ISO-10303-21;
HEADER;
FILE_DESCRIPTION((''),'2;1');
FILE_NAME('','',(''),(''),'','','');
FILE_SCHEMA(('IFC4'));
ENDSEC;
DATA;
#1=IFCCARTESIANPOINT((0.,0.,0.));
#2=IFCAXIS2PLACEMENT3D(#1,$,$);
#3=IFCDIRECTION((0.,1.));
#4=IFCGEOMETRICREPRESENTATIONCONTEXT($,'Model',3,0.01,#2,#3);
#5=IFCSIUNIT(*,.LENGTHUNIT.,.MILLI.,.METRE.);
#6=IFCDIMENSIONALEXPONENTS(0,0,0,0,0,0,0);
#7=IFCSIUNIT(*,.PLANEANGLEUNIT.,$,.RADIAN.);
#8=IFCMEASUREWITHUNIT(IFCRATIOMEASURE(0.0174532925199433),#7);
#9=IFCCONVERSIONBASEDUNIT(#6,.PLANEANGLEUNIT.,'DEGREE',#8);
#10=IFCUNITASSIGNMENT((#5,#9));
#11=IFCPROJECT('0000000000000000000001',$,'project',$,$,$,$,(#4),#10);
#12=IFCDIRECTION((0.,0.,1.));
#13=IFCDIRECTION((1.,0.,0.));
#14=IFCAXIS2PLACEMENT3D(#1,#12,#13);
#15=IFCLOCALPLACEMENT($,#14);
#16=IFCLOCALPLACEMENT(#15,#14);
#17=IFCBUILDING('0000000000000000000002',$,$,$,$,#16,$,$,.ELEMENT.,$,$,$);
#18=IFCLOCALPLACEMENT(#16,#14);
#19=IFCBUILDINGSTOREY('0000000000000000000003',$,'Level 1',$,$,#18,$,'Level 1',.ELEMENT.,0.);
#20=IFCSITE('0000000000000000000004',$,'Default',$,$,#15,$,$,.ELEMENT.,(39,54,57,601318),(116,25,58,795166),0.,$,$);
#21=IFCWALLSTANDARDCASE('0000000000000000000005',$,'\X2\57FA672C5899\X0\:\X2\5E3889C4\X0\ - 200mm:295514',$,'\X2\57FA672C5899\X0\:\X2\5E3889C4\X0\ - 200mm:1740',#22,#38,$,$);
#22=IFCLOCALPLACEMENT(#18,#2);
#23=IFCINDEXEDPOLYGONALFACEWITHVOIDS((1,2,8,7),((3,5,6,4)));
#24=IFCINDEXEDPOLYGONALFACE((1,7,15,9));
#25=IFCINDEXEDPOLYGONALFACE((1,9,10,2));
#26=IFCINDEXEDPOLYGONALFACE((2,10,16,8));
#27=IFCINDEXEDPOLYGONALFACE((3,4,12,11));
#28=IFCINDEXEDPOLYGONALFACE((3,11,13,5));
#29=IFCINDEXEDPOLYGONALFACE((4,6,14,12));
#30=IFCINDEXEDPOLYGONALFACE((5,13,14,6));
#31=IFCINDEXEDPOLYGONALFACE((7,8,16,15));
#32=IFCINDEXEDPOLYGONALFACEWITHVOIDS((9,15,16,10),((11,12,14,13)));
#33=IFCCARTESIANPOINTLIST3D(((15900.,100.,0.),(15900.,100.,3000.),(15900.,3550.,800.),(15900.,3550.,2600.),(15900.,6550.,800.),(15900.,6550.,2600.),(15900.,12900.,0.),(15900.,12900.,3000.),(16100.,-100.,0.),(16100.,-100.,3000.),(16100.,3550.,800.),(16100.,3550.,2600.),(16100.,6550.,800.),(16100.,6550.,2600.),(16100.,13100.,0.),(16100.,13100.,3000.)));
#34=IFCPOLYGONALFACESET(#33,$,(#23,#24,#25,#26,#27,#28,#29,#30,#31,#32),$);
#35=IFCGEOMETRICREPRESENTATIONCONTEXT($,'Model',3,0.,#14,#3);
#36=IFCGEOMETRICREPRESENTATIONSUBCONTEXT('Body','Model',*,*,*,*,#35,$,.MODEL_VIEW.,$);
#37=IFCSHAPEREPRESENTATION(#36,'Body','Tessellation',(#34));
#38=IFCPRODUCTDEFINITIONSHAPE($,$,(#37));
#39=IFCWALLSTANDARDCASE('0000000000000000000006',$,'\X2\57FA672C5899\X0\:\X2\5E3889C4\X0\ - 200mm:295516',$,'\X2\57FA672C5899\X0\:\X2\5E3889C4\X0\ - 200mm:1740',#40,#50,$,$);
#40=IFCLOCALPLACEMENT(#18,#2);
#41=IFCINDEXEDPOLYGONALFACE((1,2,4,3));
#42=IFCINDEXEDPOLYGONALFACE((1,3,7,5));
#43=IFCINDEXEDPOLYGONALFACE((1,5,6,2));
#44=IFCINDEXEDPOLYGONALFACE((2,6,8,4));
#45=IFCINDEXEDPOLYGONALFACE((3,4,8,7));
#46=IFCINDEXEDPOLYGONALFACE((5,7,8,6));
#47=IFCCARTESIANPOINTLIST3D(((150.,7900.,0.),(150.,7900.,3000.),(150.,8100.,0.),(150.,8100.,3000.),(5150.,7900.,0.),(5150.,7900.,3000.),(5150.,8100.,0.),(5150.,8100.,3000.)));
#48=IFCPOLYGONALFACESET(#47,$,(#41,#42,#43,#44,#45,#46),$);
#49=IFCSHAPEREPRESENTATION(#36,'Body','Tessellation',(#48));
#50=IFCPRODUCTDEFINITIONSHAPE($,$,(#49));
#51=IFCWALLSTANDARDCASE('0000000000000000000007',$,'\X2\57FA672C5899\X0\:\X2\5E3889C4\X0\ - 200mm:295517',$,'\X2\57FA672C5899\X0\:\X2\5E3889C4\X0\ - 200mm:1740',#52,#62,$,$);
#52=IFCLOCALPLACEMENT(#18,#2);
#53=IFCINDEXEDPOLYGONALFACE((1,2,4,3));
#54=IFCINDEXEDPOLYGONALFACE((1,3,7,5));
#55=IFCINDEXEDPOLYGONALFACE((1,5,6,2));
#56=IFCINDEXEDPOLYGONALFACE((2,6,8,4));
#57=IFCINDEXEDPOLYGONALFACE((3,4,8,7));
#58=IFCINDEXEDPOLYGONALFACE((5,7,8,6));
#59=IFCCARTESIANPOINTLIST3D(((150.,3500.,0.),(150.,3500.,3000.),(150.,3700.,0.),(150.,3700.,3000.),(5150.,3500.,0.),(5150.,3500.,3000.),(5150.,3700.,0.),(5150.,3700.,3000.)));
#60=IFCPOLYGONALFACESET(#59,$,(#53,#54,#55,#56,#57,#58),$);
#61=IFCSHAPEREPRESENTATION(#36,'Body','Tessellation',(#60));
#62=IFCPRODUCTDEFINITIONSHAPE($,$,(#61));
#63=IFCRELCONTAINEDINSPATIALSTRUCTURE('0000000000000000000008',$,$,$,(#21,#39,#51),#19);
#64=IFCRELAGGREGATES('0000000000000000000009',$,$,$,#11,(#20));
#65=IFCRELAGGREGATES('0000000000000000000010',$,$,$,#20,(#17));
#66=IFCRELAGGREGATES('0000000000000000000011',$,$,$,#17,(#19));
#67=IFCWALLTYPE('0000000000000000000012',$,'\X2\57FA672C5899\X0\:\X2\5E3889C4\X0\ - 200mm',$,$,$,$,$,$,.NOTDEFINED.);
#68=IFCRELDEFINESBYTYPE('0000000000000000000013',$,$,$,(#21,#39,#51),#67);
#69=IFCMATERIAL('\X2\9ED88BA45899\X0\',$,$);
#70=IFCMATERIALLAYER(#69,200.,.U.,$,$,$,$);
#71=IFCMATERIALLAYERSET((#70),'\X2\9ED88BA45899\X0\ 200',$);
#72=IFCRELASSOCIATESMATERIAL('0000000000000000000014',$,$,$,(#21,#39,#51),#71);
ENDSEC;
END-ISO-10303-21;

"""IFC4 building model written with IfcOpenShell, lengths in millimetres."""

from ifc_helpers import new_model, entity, si_unit, converted_unit, direction, frame, origin, origin_with_axes, place, context, subcontext, project, spatial, polyline, outline, extrude, material, layer, layer_set, layer_usage, type_object, element, save


model = new_model("IFC4")

# Units and contexts
model_context_1 = context("Model", 3, precision=0.01, world=origin(), true_north=direction((0.0, 1.0)))
model_context_2 = context("Model", 3, precision=0.0, world=origin_with_axes(), true_north=direction((0.0, 1.0)))
body_context = subcontext(model_context_2, "Body", "Model", "MODEL_VIEW")
ifc_project = project(units=[si_unit("LENGTHUNIT", "METRE", prefix="MILLI"), converted_unit("PLANEANGLEUNIT", "DEGREE", entity("IfcRatioMeasure", 0.0174532925199433), si_unit("PLANEANGLEUNIT", "RADIAN"), dimensions=[0, 0, 0, 0, 0, 0, 0])], contexts=[model_context_1])

# Site, building, storey
site_placement = place(None, origin_with_axes())
site = spatial("IfcSite", under=ifc_project, at=site_placement, Name="Default", CompositionType="ELEMENT", RefLatitude=(39, 54, 57, 601318), RefLongitude=(116, 25, 58, 795166), RefElevation=0.0)
building_placement = place(site_placement, origin_with_axes())
building = spatial("IfcBuilding", under=site, at=building_placement, CompositionType="ELEMENT")
storey_placement = place(building_placement, origin_with_axes())
storey = spatial("IfcBuildingStorey", under=building, at=storey_placement, Name="Level 1", LongName="Level 1", CompositionType="ELEMENT", Elevation=0.0)

# Shared definitions
ifc_material_1 = material(Name="默认墙")
ifc_layer_1 = layer(ifc_material_1, 200.0, ventilated="UNKNOWN")
ifc_layer_set_1 = layer_set([ifc_layer_1], Name="默认墙 200")
wall_type = type_object("IfcWallType", Name="基本墙:常规 - 200mm", PredefinedType="NOTDEFINED")

# Wall, opening
ifc_layer_usage_1 = layer_usage(ifc_layer_set_1, "AXIS2", "POSITIVE", -100.0)
wall_1_placement = place(storey_placement, frame((16000.0, 13000.0, 0.0), z_axis=(0.0, 0.0, 1.0), x_axis=(0.0, -1.0, 0.0)))
wall_1 = element("IfcWallStandardCase", 1, at=wall_1_placement, inside=storey, type_object=wall_type, material=ifc_layer_usage_1, Name="基本墙:常规 - 200mm:295514", ObjectType="基本墙:常规 - 200mm:1740", context=body_context, shape_type="SweptSolid", body=[
    extrude(outline(polyline([(100.0, -100.0), (12900.0, -100.0), (13100.0, 100.0), (-100.0, 100.0), (100.0, -100.0)])), origin_with_axes(), (0.0, 0.0, 1.0), 3000.0),
])
opening_1_placement = place(wall_1_placement, frame((7950.0, 0.0, 800.0), z_axis=(0.0, 0.0, 1.0), x_axis=(1.0, 0.0, 0.0)))
element("IfcOpeningElement", 2, at=opening_1_placement, cuts=wall_1, context=body_context, shape_type="SweptSolid", body=[
    extrude(outline(polyline([(-1500.0, 0.0), (-1500.0, -1800.0), (1500.0, -1800.0), (1500.0, 0.0), (-1500.0, 0.0)])), frame((0.0, -100.0, 0.0), z_axis=(0.0, 1.0, 0.0), x_axis=(1.0, 0.0, 0.0)), (0.0, 0.0, 1.0), 200.0),
])

# Walls
ifc_layer_usage_2 = layer_usage(ifc_layer_set_1, "AXIS2", "POSITIVE", -100.0)
wall_2_placement = place(storey_placement, frame((150.0, 8000.0, 0.0), z_axis=(0.0, 0.0, 1.0), x_axis=(1.0, 0.0, 0.0)))
element("IfcWallStandardCase", 3, at=wall_2_placement, inside=storey, type_object=wall_type, material=ifc_layer_usage_2, Name="基本墙:常规 - 200mm:295516", ObjectType="基本墙:常规 - 200mm:1740", context=body_context, shape_type="SweptSolid", body=[
    extrude(outline(polyline([(0.0, -100.0), (5000.0, -100.0), (5000.0, 100.0), (0.0, 100.0), (0.0, -100.0)])), origin_with_axes(), (0.0, 0.0, 1.0), 3000.0),
])
ifc_layer_usage_3 = layer_usage(ifc_layer_set_1, "AXIS2", "POSITIVE", -100.0)
wall_3_placement = place(storey_placement, frame((150.0, 3600.0, 0.0), z_axis=(0.0, 0.0, 1.0), x_axis=(1.0, 0.0, 0.0)))
element("IfcWallStandardCase", 4, at=wall_3_placement, inside=storey, type_object=wall_type, material=ifc_layer_usage_3, Name="基本墙:常规 - 200mm:295517", ObjectType="基本墙:常规 - 200mm:1740", context=body_context, shape_type="SweptSolid", body=[
    extrude(outline(polyline([(0.0, -100.0), (5000.0, -100.0), (5000.0, 100.0), (0.0, 100.0), (0.0, -100.0)])), origin_with_axes(), (0.0, 0.0, 1.0), 3000.0),
])

save(model, "model.ifc")
